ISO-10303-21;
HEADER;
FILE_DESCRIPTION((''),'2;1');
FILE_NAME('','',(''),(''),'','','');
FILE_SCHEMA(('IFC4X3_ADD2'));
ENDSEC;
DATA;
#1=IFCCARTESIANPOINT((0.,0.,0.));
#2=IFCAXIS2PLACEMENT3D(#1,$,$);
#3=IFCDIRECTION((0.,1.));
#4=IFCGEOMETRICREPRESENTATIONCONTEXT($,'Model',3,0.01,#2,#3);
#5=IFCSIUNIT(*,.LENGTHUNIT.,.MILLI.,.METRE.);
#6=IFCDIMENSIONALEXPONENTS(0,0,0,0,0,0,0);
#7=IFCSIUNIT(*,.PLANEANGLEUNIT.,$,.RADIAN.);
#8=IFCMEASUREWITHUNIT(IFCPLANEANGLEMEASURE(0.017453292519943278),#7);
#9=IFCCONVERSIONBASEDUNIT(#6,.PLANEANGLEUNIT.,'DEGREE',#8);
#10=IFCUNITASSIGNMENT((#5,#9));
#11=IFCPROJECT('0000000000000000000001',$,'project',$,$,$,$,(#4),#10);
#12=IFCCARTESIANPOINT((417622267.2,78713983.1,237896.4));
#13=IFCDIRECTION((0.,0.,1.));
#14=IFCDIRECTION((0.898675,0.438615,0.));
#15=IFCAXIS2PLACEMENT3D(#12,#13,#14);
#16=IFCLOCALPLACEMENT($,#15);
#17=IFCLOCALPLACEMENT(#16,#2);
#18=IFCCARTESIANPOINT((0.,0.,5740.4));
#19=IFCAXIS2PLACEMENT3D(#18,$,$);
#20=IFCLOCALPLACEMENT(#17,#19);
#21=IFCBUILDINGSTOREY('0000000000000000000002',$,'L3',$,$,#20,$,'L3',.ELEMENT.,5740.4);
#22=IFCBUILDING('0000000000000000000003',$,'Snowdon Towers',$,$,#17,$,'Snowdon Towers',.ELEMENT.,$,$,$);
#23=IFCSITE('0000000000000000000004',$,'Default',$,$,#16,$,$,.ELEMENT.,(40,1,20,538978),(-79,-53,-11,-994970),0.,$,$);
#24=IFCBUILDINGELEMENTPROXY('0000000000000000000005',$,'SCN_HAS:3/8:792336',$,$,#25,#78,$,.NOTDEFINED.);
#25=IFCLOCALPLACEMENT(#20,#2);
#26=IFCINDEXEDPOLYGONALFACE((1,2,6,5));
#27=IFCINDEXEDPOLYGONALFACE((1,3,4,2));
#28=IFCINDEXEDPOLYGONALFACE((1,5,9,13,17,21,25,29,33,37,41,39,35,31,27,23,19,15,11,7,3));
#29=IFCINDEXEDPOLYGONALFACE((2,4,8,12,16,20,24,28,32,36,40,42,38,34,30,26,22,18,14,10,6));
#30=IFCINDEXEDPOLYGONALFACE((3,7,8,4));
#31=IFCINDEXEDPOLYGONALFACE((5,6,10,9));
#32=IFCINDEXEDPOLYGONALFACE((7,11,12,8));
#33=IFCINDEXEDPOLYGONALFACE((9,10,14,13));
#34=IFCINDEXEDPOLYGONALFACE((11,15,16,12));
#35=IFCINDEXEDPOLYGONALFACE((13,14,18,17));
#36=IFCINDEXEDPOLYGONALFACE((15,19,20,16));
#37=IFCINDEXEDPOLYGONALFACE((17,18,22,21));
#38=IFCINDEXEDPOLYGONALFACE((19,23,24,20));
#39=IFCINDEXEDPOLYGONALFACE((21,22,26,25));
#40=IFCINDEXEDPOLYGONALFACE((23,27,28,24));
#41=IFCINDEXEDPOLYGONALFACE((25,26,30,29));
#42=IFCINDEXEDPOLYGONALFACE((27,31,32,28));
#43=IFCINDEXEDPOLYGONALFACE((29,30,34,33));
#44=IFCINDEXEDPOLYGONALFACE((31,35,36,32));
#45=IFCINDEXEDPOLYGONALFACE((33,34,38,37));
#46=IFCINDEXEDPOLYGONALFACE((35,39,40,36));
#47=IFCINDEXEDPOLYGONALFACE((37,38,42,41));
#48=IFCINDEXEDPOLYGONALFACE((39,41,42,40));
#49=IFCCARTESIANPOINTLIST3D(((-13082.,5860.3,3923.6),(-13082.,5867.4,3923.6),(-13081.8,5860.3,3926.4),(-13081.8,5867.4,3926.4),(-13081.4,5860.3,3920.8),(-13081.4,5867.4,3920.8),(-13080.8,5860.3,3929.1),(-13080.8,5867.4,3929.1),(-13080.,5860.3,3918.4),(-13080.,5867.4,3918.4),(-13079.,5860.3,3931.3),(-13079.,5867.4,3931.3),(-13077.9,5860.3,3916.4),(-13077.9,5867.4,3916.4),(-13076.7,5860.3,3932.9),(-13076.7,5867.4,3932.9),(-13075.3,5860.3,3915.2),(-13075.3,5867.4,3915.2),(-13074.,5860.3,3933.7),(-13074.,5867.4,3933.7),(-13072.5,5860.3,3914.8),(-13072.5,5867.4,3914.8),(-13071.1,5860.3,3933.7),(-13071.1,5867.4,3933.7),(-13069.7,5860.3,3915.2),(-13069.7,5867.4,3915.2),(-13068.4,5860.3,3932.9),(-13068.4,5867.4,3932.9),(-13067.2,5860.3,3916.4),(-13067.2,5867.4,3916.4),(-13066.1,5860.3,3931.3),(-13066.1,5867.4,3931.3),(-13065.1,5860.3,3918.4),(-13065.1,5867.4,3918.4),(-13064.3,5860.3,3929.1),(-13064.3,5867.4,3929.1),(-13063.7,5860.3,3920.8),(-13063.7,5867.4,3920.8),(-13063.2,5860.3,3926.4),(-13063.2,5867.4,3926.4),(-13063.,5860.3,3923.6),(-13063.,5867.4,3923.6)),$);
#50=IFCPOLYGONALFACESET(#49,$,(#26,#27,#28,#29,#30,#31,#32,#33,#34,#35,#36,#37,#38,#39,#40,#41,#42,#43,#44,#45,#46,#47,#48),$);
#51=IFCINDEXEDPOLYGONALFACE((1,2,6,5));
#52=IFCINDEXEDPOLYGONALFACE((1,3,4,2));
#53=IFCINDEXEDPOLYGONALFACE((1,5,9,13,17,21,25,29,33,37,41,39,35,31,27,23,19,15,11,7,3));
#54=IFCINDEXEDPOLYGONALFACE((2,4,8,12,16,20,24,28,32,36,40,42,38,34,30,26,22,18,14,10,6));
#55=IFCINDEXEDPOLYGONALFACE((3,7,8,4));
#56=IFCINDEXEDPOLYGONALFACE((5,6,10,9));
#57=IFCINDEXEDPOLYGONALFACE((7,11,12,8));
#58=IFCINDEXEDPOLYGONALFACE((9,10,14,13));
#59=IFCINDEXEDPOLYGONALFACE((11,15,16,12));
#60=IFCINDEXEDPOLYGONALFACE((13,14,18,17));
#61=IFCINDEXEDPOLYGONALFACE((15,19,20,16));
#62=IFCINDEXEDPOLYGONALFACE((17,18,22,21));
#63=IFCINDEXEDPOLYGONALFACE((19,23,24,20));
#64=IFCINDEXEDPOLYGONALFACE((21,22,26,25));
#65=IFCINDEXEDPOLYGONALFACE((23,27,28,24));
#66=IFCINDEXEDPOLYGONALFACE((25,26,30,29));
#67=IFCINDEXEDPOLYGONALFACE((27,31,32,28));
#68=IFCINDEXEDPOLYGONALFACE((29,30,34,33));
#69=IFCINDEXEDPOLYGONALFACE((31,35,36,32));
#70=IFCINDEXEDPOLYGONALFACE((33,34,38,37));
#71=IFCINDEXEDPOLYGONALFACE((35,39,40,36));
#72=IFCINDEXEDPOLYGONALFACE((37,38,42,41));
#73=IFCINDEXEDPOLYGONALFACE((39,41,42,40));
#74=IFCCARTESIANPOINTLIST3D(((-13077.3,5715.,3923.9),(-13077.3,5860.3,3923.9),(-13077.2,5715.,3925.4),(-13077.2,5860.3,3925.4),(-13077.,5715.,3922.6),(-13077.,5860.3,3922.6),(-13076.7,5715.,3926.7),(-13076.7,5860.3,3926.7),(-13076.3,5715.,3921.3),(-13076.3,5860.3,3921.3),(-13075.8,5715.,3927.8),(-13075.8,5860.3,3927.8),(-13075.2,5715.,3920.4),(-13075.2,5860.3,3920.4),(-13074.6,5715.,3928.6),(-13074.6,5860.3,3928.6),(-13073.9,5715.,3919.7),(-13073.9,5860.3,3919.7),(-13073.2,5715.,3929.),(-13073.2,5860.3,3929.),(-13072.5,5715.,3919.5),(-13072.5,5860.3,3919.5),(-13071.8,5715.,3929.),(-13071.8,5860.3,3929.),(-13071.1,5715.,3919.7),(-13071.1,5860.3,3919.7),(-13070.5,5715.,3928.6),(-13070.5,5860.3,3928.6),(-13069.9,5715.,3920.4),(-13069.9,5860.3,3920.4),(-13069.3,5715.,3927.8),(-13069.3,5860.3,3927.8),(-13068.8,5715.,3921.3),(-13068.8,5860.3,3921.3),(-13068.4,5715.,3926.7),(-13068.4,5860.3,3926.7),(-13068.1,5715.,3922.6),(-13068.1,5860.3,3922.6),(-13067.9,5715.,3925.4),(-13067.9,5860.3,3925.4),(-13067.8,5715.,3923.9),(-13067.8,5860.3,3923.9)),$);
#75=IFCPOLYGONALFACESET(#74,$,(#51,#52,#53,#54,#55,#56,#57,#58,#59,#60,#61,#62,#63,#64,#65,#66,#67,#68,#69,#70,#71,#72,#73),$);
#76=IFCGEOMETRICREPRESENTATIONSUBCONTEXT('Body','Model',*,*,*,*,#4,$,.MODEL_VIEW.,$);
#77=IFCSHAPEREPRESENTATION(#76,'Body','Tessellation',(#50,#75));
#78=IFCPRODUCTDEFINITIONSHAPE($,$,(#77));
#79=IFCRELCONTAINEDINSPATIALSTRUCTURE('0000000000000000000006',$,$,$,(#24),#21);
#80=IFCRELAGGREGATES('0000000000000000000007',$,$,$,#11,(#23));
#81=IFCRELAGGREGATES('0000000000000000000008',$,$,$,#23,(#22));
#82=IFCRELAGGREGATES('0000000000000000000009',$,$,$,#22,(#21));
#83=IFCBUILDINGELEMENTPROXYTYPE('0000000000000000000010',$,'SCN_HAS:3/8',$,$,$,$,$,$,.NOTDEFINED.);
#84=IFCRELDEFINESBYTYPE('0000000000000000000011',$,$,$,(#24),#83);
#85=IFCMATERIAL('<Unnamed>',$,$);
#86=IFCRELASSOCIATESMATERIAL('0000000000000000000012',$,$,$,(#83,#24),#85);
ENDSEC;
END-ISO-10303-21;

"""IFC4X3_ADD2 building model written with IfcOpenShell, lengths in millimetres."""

from ifc_helpers import new_model, entity, si_unit, converted_unit, direction, frame, frame_2d, origin, place, context, subcontext, project, spatial, circle, extrude, source, transform, mapped, material, type_object, type_shapes, element, save


model = new_model("IFC4X3_ADD2")

# Units and contexts
model_context = context("Model", 3, precision=0.01, world=origin(), true_north=direction((0.0, 1.0)))
body_context = subcontext(model_context, "Body", "Model", "MODEL_VIEW")
ifc_project = project(units=[si_unit("LENGTHUNIT", "METRE", prefix="MILLI"), converted_unit("PLANEANGLEUNIT", "DEGREE", entity("IfcPlaneAngleMeasure", 0.017453292519943278), si_unit("PLANEANGLEUNIT", "RADIAN"), dimensions=[0, 0, 0, 0, 0, 0, 0])], contexts=[model_context])

# Site, building, storey
site_placement = place(None, frame((417622267.2, 78713983.1, 237896.4), z_axis=(0.0, 0.0, 1.0), x_axis=(0.898675, 0.438615, 0.0)))
site = spatial("IfcSite", under=ifc_project, at=site_placement, Name="Default", CompositionType="ELEMENT", RefLatitude=(40, 1, 20, 538978), RefLongitude=(-79, -53, -11, -994970), RefElevation=0.0)
building_placement = place(site_placement, origin())
building = spatial("IfcBuilding", under=site, at=building_placement, Name="Snowdon Towers", LongName="Snowdon Towers", CompositionType="ELEMENT")
storey_placement = place(building_placement, frame((0.0, 0.0, 5740.4)))
storey = spatial("IfcBuildingStorey", under=building, at=storey_placement, Name="L3", LongName="L3", CompositionType="ELEMENT", Elevation=5740.4)

# Building element proxy
ifc_material_1 = material(Name="<Unnamed>")
building_element_proxy_type_1 = type_object("IfcBuildingElementProxyType", Name="SCN_HAS:3/8", PredefinedType="NOTDEFINED", material=ifc_material_1)
shared_shape_1 = source(origin(), body_context, "Body", "SweptSolid", [
    extrude(circle(Radius=9.5, at=frame_2d((0.0, 0.0), x_axis=(1.0, 0.0))), frame((0.0, 0.0, -152.4), z_axis=(0.0, 0.0, 1.0), x_axis=(0.0, -1.0, 0.0)), (0.0, 0.0, 1.0), 7.1),
    extrude(circle(Radius=4.8, at=frame_2d((0.0, 0.0), x_axis=(1.0, 0.0))), frame((0.0, 0.0, -145.3), z_axis=(0.0, 0.0, 1.0), x_axis=(0.0, -1.0, 0.0)), (0.0, 0.0, 1.0), 145.3),
])
type_shapes(building_element_proxy_type_1, [shared_shape_1])
for number, where, z_axis, x_axis, name in (
    (1, (-13072.5, 5715.0, 3924.3), (0.0, -1.0, 0.0), (1.0, 0.0, 0.0), "SCN_HAS:3/8:792336"),
):
    element("IfcBuildingElementProxy", number, at=place(storey_placement, frame(where, z_axis=z_axis, x_axis=x_axis)), inside=storey, type_object=building_element_proxy_type_1, material=ifc_material_1, Name=name, PredefinedType="NOTDEFINED", context=body_context, shape_type="MappedRepresentation", body=[
        mapped(shared_shape_1, transform((0.0, 0.0, 0.0), scale=1.0)),
    ])

save(model, "model.ifc")
